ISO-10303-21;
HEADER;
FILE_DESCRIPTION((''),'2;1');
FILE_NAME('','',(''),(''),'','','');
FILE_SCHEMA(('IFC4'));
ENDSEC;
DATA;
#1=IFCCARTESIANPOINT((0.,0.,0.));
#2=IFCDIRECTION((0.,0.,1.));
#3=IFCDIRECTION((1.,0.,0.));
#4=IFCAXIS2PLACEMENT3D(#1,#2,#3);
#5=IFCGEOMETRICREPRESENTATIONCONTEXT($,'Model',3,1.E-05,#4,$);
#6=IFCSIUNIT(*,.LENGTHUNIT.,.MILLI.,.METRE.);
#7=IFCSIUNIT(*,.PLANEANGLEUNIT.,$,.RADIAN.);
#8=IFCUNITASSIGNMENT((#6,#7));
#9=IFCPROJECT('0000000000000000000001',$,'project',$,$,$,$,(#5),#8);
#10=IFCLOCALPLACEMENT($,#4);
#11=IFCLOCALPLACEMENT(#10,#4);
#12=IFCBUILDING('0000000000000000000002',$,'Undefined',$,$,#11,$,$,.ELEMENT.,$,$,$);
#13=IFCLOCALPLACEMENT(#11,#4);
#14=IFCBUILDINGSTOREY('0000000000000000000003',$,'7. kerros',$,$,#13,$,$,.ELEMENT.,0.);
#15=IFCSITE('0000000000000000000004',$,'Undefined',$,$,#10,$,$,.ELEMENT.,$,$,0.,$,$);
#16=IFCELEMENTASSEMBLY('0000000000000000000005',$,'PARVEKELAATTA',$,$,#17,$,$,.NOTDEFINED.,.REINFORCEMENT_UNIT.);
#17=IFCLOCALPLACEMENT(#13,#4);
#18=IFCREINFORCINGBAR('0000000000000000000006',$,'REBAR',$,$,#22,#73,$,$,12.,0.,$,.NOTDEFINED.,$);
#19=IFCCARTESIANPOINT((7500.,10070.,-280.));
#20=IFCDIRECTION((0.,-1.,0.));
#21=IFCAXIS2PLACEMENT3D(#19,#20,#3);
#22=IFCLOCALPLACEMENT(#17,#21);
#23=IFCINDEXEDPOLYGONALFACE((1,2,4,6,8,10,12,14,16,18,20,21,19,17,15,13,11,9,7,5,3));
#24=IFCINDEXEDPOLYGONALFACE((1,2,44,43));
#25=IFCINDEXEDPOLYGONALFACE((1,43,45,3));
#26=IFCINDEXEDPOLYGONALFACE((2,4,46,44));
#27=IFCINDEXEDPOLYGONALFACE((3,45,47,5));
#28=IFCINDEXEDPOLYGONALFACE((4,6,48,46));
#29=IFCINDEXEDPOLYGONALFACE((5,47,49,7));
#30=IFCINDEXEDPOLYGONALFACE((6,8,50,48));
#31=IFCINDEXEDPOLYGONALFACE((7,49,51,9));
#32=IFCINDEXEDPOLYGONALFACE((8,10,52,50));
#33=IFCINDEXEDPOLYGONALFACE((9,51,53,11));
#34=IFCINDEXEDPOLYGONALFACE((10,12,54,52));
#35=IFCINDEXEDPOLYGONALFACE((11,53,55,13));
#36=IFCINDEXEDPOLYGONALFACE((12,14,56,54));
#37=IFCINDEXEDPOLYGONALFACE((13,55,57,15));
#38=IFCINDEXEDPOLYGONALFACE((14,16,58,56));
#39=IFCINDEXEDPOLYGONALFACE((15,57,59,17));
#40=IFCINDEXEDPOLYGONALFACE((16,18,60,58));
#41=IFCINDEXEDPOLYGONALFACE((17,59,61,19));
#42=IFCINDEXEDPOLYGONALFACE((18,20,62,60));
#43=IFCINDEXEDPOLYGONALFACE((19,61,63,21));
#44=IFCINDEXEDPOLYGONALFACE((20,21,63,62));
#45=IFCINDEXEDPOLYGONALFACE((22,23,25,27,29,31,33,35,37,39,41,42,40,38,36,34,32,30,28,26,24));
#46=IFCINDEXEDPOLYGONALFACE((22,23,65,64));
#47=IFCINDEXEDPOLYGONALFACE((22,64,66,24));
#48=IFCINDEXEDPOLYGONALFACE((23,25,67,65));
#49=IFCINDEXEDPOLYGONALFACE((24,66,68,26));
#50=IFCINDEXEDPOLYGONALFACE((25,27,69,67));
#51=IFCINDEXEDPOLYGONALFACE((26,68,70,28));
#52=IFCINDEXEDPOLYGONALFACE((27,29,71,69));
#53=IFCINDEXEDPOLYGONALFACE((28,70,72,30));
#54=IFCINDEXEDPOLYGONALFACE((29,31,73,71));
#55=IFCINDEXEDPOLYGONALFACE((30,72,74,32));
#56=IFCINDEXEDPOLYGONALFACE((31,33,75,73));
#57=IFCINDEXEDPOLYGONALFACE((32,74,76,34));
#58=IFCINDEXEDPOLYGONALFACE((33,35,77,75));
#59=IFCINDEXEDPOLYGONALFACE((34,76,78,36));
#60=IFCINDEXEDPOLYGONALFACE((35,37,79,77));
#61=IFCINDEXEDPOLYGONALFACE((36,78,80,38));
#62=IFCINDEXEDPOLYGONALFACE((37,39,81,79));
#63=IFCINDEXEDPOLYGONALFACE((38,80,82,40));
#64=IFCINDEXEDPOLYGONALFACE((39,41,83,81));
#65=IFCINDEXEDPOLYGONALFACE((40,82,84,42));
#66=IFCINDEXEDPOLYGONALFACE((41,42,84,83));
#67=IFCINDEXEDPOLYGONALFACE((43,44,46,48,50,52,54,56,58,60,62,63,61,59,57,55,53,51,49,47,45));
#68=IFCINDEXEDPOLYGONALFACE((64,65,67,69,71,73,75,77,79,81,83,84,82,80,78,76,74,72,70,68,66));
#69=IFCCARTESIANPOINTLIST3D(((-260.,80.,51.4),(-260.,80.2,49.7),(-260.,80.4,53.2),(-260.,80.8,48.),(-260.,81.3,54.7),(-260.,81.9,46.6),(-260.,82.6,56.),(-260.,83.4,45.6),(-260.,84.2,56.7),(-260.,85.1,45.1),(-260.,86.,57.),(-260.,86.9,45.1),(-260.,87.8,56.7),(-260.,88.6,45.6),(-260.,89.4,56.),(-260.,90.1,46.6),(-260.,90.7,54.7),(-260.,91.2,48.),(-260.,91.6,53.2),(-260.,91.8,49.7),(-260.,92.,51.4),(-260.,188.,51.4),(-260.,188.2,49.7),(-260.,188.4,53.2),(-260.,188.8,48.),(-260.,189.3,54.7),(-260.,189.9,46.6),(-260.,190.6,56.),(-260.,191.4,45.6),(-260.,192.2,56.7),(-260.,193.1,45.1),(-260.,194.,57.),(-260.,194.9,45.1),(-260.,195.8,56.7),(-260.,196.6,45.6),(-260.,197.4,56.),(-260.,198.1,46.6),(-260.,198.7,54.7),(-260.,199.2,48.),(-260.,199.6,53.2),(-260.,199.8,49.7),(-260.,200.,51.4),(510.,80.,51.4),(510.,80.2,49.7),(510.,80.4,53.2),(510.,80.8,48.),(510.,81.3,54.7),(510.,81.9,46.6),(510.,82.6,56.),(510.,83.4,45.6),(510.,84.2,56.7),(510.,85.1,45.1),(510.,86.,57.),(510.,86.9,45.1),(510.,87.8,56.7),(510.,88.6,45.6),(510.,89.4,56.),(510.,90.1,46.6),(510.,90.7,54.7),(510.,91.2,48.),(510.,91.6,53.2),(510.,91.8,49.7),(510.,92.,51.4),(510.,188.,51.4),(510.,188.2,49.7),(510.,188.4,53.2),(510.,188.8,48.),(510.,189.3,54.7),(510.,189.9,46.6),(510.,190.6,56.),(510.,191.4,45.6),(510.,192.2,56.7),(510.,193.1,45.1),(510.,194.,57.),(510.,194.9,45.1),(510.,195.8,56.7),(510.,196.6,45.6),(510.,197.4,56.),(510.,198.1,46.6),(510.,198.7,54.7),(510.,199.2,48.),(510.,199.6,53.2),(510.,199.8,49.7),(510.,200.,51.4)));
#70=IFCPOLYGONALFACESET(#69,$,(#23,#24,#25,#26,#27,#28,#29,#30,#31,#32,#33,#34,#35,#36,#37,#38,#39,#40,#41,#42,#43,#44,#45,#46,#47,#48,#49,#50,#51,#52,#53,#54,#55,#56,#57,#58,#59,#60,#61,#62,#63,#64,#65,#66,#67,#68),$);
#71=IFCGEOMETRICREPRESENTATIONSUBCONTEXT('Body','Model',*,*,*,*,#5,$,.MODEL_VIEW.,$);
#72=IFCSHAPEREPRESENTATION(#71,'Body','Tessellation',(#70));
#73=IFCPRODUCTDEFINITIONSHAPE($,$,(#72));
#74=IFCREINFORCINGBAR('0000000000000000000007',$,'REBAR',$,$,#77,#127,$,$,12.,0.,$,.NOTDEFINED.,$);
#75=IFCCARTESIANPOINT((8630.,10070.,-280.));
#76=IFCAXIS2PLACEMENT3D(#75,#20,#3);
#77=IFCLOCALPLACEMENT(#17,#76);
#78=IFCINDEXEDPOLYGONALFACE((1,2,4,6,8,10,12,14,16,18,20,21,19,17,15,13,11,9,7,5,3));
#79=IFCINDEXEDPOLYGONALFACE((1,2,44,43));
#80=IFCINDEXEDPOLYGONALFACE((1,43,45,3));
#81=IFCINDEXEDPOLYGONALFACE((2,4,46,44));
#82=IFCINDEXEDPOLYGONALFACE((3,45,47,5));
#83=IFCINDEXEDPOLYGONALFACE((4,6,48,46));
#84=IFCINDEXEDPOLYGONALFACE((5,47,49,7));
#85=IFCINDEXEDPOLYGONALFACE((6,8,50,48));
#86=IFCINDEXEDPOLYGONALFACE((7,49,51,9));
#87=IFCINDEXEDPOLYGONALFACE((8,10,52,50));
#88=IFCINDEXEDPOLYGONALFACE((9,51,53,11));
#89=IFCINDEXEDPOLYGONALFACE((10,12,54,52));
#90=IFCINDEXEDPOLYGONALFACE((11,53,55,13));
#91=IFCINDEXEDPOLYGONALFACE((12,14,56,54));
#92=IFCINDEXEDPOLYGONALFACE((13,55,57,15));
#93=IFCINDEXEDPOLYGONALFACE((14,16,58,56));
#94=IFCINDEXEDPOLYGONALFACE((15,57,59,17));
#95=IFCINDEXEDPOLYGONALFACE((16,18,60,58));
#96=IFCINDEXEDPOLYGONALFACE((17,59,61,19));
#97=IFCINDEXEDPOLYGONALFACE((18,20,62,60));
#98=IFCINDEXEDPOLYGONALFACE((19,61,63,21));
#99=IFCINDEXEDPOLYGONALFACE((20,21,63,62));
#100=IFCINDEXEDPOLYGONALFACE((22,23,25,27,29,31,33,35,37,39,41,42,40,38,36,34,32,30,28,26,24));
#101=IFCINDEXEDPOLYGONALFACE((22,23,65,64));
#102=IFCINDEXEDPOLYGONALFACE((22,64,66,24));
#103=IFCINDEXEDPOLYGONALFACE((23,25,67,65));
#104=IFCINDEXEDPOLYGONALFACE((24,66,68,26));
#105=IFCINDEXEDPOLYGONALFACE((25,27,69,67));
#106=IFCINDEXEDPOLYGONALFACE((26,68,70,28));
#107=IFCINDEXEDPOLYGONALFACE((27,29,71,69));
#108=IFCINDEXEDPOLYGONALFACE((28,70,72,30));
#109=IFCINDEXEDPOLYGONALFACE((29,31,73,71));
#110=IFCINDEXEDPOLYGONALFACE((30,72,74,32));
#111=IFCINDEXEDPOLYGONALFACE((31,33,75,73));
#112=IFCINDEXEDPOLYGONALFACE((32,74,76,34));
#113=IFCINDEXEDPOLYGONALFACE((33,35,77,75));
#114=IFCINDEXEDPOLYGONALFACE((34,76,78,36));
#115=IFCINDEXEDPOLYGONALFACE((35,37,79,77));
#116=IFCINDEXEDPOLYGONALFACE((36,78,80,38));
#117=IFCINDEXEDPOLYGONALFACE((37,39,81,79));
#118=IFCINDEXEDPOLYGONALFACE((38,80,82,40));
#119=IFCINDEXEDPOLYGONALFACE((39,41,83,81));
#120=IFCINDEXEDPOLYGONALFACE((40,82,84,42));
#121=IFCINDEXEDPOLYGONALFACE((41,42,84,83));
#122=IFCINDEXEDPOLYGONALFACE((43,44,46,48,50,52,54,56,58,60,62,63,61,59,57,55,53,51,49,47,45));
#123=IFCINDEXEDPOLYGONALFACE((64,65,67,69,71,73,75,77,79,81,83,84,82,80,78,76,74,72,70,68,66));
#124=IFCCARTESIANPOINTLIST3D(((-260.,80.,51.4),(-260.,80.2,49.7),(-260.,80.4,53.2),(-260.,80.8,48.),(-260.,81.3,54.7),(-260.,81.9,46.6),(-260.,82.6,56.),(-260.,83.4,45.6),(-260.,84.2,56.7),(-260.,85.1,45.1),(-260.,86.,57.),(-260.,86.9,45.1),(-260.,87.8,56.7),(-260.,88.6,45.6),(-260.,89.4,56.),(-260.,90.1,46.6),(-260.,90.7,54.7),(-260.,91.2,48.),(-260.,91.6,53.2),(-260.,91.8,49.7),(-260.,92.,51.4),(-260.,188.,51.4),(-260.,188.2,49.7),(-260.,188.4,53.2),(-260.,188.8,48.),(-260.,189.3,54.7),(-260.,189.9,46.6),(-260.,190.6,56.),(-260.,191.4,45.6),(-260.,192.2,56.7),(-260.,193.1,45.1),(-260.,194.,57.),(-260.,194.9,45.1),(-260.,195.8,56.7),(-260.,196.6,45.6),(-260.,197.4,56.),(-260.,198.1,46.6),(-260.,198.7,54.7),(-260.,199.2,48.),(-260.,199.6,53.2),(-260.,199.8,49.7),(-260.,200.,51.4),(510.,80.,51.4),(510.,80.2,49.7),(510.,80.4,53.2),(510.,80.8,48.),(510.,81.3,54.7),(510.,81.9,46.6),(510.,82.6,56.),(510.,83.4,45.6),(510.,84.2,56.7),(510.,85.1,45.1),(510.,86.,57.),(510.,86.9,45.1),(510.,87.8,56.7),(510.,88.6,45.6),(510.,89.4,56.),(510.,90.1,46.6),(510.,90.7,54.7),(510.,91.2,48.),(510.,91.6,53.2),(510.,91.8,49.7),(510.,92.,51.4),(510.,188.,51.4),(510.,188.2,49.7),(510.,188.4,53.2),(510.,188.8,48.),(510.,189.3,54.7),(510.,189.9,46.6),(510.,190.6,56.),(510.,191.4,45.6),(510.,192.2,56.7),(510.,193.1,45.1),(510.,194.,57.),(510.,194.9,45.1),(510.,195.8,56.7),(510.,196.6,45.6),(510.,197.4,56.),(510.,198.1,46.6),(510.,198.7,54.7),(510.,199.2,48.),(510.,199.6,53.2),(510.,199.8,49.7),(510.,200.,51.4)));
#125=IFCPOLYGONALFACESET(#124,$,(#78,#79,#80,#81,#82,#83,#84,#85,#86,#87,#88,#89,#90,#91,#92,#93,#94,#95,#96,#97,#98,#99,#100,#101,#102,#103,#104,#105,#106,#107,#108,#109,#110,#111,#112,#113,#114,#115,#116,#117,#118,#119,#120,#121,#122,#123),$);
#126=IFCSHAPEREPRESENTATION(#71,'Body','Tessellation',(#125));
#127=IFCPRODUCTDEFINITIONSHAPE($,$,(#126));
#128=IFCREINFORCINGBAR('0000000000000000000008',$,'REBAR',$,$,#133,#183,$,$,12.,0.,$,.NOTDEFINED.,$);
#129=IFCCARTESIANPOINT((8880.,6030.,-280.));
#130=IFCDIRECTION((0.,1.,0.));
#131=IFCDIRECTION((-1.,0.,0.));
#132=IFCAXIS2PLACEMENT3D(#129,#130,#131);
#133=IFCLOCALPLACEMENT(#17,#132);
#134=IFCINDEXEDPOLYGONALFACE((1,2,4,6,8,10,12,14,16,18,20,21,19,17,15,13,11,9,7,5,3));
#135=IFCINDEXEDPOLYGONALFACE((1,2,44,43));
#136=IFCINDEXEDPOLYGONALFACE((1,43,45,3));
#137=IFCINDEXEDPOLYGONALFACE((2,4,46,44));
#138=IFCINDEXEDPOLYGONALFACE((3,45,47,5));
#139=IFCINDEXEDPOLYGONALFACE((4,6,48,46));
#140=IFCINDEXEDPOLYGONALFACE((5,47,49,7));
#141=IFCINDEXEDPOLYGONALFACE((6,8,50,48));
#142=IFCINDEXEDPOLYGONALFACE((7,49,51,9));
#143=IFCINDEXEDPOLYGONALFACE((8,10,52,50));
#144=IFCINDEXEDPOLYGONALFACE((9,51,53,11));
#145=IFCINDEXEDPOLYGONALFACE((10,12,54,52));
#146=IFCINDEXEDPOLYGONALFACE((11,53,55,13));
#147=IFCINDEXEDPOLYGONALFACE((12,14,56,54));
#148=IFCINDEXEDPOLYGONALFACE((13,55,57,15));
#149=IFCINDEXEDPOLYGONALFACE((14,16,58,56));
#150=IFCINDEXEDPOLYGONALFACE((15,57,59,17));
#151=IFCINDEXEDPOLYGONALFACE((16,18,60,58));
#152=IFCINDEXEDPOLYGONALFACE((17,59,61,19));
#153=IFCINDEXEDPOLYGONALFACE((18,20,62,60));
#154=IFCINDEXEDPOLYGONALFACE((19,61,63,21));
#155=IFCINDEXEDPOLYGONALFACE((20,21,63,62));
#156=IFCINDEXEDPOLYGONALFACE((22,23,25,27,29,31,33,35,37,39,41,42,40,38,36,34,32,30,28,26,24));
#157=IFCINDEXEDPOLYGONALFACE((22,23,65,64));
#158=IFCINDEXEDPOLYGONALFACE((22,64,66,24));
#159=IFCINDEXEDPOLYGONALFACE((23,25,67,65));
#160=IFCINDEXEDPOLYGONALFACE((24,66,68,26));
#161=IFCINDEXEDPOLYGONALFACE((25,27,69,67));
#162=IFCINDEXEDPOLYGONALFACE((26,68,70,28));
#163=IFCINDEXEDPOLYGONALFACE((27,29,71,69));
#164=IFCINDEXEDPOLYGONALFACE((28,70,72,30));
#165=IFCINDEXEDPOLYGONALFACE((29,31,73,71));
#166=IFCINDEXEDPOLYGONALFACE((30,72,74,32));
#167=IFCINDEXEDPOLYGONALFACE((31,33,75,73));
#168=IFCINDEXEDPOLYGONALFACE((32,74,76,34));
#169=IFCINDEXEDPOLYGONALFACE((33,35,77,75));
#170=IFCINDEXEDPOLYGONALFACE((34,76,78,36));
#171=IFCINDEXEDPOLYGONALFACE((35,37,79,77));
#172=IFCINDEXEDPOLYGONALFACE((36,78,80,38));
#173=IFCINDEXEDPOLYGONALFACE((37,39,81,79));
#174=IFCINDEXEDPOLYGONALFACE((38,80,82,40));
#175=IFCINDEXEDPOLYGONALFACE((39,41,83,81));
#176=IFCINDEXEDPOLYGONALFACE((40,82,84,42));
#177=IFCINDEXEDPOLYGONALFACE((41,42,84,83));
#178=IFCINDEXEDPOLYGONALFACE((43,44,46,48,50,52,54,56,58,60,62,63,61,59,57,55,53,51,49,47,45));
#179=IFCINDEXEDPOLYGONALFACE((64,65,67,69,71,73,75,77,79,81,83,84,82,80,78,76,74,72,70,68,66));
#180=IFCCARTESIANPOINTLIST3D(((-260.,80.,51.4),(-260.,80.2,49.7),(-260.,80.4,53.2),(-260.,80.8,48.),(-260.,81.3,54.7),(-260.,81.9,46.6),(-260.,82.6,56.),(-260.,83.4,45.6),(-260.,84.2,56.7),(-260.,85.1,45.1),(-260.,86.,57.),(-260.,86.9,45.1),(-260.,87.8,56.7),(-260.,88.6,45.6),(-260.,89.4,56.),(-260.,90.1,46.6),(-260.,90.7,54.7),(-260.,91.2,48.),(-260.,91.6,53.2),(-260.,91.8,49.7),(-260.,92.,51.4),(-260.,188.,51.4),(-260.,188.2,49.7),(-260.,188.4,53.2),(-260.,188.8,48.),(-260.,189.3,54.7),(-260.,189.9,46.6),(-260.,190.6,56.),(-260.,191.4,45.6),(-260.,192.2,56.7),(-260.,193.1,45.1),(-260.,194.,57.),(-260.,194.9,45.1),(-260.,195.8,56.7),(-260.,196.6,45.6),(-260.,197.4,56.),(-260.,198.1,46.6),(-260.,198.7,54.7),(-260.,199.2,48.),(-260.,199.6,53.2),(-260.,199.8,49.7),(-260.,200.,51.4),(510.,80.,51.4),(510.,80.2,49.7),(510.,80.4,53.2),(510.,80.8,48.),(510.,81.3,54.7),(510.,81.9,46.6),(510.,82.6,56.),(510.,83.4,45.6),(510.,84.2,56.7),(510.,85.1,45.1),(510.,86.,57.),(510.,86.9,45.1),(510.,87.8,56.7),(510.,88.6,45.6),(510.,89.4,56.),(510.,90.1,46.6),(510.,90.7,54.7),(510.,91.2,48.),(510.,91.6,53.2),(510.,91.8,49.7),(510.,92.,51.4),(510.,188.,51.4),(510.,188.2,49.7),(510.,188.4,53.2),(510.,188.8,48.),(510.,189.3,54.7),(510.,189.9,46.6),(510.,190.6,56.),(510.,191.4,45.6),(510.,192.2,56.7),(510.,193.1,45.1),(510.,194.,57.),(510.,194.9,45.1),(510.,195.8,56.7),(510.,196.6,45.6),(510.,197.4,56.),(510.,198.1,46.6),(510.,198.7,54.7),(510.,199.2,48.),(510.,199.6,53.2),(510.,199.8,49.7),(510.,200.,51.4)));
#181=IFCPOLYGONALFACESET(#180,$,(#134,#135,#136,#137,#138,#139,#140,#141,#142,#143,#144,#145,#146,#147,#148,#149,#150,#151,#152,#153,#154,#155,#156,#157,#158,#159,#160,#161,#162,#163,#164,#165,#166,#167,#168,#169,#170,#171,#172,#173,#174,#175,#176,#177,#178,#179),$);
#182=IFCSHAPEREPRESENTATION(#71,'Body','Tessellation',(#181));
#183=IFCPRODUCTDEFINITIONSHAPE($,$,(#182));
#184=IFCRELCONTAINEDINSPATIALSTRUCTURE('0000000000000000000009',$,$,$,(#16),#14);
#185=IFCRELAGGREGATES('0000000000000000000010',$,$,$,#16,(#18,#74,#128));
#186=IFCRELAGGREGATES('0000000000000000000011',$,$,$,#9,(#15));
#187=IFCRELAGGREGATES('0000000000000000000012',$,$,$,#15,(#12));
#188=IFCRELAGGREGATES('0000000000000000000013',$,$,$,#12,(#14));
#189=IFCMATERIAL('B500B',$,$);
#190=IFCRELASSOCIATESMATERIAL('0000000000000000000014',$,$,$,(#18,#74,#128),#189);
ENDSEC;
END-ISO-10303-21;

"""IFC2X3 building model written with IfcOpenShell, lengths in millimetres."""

from ifc_helpers import new_model, entity, si_unit, frame, origin_with_axes, place, context, subcontext, project, spatial, source, transform, mapped, material, element, aggregate, save


model = new_model("IFC2X3")

# Units and contexts
model_context = context("Model", 3, precision=1e-05, world=origin_with_axes())
body_context = subcontext(model_context, "Body", "Model", "MODEL_VIEW")
ifc_project = project(units=[si_unit("LENGTHUNIT", "METRE", prefix="MILLI"), si_unit("PLANEANGLEUNIT", "RADIAN")], contexts=[model_context])

# Site, building, storey
site_placement = place(None, origin_with_axes())
site = spatial("IfcSite", under=ifc_project, at=site_placement, Name="Undefined", CompositionType="ELEMENT", RefElevation=0.0)
building_placement = place(site_placement, origin_with_axes())
building = spatial("IfcBuilding", under=site, at=building_placement, Name="Undefined", CompositionType="ELEMENT")
storey_placement = place(building_placement, origin_with_axes())
storey = spatial("IfcBuildingStorey", under=building, at=storey_placement, Name="7. kerros", CompositionType="ELEMENT", Elevation=0.0)

# Element assembly, reinforcing bars
assembly_placement = place(storey_placement, origin_with_axes())
assembly = element("IfcElementAssembly", 1, at=assembly_placement, inside=storey, Name="PARVEKELAATTA", AssemblyPlace="NOTDEFINED", PredefinedType="REINFORCEMENT_UNIT")
ifc_material_1 = material(Name="B500B")
shared_shape_1 = source(origin_with_axes(), body_context, "Body", "AdvancedSweptSolid", [
    entity("IfcSweptDiskSolid", entity("IfcTrimmedCurve", entity("IfcLine", entity("IfcCartesianPoint", [0.0, 0.0, 0.0]), entity("IfcVector", entity("IfcDirection", [1.0, 0.0, 0.0]), 1.0)), [entity("IfcParameterValue", 0.0)], [entity("IfcParameterValue", 770.0)], True, "PARAMETER"), 6.0, None, 0.0, 770.0),
])
shared_shape_2 = source(origin_with_axes(), body_context, "Body", "AdvancedSweptSolid", [
    entity("IfcSweptDiskSolid", entity("IfcTrimmedCurve", entity("IfcLine", entity("IfcCartesianPoint", [0.0, 0.0, 0.0]), entity("IfcVector", entity("IfcDirection", [1.0, 0.0, 0.0]), 1.0)), [entity("IfcParameterValue", 0.0)], [entity("IfcParameterValue", 770.0)], True, "PARAMETER"), 6.0, None, 0.0, 770.0),
])
reinforcing_bar_1_placement = place(assembly_placement, frame((7500.0, 10070.0, -280.0), z_axis=(0.0, -1.0, 0.0), x_axis=(1.0, 0.0, 0.0)))
reinforcing_bar_1 = element("IfcReinforcingBar", 2, at=reinforcing_bar_1_placement, material=ifc_material_1, Name="REBAR", BarRole="NOTDEFINED", CrossSectionArea=0.0, NominalDiameter=12.0, context=body_context, shape_type="MappedRepresentation", body=[
    mapped(shared_shape_1, transform((-260.0, 86.0, 51.0))),
    mapped(shared_shape_2, transform((-260.0, 194.0, 51.0))),
])
shared_shape_3 = source(origin_with_axes(), body_context, "Body", "AdvancedSweptSolid", [
    entity("IfcSweptDiskSolid", entity("IfcTrimmedCurve", entity("IfcLine", entity("IfcCartesianPoint", [0.0, 0.0, 0.0]), entity("IfcVector", entity("IfcDirection", [1.0, 0.0, 0.0]), 1.0)), [entity("IfcParameterValue", 0.0)], [entity("IfcParameterValue", 770.0)], True, "PARAMETER"), 6.0, None, 0.0, 770.0),
])
shared_shape_4 = source(origin_with_axes(), body_context, "Body", "AdvancedSweptSolid", [
    entity("IfcSweptDiskSolid", entity("IfcTrimmedCurve", entity("IfcLine", entity("IfcCartesianPoint", [0.0, 0.0, 0.0]), entity("IfcVector", entity("IfcDirection", [1.0, 0.0, 0.0]), 1.0)), [entity("IfcParameterValue", 0.0)], [entity("IfcParameterValue", 770.0)], True, "PARAMETER"), 6.0, None, 0.0, 770.0),
])
reinforcing_bar_2_placement = place(assembly_placement, frame((8630.0, 10070.0, -280.0), z_axis=(0.0, -1.0, 0.0), x_axis=(1.0, 0.0, 0.0)))
reinforcing_bar_2 = element("IfcReinforcingBar", 3, at=reinforcing_bar_2_placement, material=ifc_material_1, Name="REBAR", BarRole="NOTDEFINED", CrossSectionArea=0.0, NominalDiameter=12.0, context=body_context, shape_type="MappedRepresentation", body=[
    mapped(shared_shape_3, transform((-260.0, 86.0, 51.0))),
    mapped(shared_shape_4, transform((-260.0, 194.0, 51.0))),
])
shared_shape_5 = source(origin_with_axes(), body_context, "Body", "AdvancedSweptSolid", [
    entity("IfcSweptDiskSolid", entity("IfcTrimmedCurve", entity("IfcLine", entity("IfcCartesianPoint", [0.0, 0.0, 0.0]), entity("IfcVector", entity("IfcDirection", [1.0, 0.0, 0.0]), 1.0)), [entity("IfcParameterValue", 0.0)], [entity("IfcParameterValue", 770.0)], True, "PARAMETER"), 6.0, None, 0.0, 770.0),
])
shared_shape_6 = source(origin_with_axes(), body_context, "Body", "AdvancedSweptSolid", [
    entity("IfcSweptDiskSolid", entity("IfcTrimmedCurve", entity("IfcLine", entity("IfcCartesianPoint", [0.0, 0.0, 0.0]), entity("IfcVector", entity("IfcDirection", [1.0, 0.0, 0.0]), 1.0)), [entity("IfcParameterValue", 0.0)], [entity("IfcParameterValue", 770.0)], True, "PARAMETER"), 6.0, None, 0.0, 770.0),
])
reinforcing_bar_3_placement = place(assembly_placement, frame((8880.0, 6030.0, -280.0), z_axis=(0.0, 1.0, 0.0), x_axis=(-1.0, 0.0, 0.0)))
reinforcing_bar_3 = element("IfcReinforcingBar", 4, at=reinforcing_bar_3_placement, material=ifc_material_1, Name="REBAR", BarRole="NOTDEFINED", CrossSectionArea=0.0, NominalDiameter=12.0, context=body_context, shape_type="MappedRepresentation", body=[
    mapped(shared_shape_5, transform((-260.0, 86.0, 51.0))),
    mapped(shared_shape_6, transform((-260.0, 194.0, 51.0))),
])
aggregate(assembly, [reinforcing_bar_1, reinforcing_bar_2, reinforcing_bar_3])

save(model, "model.ifc")
